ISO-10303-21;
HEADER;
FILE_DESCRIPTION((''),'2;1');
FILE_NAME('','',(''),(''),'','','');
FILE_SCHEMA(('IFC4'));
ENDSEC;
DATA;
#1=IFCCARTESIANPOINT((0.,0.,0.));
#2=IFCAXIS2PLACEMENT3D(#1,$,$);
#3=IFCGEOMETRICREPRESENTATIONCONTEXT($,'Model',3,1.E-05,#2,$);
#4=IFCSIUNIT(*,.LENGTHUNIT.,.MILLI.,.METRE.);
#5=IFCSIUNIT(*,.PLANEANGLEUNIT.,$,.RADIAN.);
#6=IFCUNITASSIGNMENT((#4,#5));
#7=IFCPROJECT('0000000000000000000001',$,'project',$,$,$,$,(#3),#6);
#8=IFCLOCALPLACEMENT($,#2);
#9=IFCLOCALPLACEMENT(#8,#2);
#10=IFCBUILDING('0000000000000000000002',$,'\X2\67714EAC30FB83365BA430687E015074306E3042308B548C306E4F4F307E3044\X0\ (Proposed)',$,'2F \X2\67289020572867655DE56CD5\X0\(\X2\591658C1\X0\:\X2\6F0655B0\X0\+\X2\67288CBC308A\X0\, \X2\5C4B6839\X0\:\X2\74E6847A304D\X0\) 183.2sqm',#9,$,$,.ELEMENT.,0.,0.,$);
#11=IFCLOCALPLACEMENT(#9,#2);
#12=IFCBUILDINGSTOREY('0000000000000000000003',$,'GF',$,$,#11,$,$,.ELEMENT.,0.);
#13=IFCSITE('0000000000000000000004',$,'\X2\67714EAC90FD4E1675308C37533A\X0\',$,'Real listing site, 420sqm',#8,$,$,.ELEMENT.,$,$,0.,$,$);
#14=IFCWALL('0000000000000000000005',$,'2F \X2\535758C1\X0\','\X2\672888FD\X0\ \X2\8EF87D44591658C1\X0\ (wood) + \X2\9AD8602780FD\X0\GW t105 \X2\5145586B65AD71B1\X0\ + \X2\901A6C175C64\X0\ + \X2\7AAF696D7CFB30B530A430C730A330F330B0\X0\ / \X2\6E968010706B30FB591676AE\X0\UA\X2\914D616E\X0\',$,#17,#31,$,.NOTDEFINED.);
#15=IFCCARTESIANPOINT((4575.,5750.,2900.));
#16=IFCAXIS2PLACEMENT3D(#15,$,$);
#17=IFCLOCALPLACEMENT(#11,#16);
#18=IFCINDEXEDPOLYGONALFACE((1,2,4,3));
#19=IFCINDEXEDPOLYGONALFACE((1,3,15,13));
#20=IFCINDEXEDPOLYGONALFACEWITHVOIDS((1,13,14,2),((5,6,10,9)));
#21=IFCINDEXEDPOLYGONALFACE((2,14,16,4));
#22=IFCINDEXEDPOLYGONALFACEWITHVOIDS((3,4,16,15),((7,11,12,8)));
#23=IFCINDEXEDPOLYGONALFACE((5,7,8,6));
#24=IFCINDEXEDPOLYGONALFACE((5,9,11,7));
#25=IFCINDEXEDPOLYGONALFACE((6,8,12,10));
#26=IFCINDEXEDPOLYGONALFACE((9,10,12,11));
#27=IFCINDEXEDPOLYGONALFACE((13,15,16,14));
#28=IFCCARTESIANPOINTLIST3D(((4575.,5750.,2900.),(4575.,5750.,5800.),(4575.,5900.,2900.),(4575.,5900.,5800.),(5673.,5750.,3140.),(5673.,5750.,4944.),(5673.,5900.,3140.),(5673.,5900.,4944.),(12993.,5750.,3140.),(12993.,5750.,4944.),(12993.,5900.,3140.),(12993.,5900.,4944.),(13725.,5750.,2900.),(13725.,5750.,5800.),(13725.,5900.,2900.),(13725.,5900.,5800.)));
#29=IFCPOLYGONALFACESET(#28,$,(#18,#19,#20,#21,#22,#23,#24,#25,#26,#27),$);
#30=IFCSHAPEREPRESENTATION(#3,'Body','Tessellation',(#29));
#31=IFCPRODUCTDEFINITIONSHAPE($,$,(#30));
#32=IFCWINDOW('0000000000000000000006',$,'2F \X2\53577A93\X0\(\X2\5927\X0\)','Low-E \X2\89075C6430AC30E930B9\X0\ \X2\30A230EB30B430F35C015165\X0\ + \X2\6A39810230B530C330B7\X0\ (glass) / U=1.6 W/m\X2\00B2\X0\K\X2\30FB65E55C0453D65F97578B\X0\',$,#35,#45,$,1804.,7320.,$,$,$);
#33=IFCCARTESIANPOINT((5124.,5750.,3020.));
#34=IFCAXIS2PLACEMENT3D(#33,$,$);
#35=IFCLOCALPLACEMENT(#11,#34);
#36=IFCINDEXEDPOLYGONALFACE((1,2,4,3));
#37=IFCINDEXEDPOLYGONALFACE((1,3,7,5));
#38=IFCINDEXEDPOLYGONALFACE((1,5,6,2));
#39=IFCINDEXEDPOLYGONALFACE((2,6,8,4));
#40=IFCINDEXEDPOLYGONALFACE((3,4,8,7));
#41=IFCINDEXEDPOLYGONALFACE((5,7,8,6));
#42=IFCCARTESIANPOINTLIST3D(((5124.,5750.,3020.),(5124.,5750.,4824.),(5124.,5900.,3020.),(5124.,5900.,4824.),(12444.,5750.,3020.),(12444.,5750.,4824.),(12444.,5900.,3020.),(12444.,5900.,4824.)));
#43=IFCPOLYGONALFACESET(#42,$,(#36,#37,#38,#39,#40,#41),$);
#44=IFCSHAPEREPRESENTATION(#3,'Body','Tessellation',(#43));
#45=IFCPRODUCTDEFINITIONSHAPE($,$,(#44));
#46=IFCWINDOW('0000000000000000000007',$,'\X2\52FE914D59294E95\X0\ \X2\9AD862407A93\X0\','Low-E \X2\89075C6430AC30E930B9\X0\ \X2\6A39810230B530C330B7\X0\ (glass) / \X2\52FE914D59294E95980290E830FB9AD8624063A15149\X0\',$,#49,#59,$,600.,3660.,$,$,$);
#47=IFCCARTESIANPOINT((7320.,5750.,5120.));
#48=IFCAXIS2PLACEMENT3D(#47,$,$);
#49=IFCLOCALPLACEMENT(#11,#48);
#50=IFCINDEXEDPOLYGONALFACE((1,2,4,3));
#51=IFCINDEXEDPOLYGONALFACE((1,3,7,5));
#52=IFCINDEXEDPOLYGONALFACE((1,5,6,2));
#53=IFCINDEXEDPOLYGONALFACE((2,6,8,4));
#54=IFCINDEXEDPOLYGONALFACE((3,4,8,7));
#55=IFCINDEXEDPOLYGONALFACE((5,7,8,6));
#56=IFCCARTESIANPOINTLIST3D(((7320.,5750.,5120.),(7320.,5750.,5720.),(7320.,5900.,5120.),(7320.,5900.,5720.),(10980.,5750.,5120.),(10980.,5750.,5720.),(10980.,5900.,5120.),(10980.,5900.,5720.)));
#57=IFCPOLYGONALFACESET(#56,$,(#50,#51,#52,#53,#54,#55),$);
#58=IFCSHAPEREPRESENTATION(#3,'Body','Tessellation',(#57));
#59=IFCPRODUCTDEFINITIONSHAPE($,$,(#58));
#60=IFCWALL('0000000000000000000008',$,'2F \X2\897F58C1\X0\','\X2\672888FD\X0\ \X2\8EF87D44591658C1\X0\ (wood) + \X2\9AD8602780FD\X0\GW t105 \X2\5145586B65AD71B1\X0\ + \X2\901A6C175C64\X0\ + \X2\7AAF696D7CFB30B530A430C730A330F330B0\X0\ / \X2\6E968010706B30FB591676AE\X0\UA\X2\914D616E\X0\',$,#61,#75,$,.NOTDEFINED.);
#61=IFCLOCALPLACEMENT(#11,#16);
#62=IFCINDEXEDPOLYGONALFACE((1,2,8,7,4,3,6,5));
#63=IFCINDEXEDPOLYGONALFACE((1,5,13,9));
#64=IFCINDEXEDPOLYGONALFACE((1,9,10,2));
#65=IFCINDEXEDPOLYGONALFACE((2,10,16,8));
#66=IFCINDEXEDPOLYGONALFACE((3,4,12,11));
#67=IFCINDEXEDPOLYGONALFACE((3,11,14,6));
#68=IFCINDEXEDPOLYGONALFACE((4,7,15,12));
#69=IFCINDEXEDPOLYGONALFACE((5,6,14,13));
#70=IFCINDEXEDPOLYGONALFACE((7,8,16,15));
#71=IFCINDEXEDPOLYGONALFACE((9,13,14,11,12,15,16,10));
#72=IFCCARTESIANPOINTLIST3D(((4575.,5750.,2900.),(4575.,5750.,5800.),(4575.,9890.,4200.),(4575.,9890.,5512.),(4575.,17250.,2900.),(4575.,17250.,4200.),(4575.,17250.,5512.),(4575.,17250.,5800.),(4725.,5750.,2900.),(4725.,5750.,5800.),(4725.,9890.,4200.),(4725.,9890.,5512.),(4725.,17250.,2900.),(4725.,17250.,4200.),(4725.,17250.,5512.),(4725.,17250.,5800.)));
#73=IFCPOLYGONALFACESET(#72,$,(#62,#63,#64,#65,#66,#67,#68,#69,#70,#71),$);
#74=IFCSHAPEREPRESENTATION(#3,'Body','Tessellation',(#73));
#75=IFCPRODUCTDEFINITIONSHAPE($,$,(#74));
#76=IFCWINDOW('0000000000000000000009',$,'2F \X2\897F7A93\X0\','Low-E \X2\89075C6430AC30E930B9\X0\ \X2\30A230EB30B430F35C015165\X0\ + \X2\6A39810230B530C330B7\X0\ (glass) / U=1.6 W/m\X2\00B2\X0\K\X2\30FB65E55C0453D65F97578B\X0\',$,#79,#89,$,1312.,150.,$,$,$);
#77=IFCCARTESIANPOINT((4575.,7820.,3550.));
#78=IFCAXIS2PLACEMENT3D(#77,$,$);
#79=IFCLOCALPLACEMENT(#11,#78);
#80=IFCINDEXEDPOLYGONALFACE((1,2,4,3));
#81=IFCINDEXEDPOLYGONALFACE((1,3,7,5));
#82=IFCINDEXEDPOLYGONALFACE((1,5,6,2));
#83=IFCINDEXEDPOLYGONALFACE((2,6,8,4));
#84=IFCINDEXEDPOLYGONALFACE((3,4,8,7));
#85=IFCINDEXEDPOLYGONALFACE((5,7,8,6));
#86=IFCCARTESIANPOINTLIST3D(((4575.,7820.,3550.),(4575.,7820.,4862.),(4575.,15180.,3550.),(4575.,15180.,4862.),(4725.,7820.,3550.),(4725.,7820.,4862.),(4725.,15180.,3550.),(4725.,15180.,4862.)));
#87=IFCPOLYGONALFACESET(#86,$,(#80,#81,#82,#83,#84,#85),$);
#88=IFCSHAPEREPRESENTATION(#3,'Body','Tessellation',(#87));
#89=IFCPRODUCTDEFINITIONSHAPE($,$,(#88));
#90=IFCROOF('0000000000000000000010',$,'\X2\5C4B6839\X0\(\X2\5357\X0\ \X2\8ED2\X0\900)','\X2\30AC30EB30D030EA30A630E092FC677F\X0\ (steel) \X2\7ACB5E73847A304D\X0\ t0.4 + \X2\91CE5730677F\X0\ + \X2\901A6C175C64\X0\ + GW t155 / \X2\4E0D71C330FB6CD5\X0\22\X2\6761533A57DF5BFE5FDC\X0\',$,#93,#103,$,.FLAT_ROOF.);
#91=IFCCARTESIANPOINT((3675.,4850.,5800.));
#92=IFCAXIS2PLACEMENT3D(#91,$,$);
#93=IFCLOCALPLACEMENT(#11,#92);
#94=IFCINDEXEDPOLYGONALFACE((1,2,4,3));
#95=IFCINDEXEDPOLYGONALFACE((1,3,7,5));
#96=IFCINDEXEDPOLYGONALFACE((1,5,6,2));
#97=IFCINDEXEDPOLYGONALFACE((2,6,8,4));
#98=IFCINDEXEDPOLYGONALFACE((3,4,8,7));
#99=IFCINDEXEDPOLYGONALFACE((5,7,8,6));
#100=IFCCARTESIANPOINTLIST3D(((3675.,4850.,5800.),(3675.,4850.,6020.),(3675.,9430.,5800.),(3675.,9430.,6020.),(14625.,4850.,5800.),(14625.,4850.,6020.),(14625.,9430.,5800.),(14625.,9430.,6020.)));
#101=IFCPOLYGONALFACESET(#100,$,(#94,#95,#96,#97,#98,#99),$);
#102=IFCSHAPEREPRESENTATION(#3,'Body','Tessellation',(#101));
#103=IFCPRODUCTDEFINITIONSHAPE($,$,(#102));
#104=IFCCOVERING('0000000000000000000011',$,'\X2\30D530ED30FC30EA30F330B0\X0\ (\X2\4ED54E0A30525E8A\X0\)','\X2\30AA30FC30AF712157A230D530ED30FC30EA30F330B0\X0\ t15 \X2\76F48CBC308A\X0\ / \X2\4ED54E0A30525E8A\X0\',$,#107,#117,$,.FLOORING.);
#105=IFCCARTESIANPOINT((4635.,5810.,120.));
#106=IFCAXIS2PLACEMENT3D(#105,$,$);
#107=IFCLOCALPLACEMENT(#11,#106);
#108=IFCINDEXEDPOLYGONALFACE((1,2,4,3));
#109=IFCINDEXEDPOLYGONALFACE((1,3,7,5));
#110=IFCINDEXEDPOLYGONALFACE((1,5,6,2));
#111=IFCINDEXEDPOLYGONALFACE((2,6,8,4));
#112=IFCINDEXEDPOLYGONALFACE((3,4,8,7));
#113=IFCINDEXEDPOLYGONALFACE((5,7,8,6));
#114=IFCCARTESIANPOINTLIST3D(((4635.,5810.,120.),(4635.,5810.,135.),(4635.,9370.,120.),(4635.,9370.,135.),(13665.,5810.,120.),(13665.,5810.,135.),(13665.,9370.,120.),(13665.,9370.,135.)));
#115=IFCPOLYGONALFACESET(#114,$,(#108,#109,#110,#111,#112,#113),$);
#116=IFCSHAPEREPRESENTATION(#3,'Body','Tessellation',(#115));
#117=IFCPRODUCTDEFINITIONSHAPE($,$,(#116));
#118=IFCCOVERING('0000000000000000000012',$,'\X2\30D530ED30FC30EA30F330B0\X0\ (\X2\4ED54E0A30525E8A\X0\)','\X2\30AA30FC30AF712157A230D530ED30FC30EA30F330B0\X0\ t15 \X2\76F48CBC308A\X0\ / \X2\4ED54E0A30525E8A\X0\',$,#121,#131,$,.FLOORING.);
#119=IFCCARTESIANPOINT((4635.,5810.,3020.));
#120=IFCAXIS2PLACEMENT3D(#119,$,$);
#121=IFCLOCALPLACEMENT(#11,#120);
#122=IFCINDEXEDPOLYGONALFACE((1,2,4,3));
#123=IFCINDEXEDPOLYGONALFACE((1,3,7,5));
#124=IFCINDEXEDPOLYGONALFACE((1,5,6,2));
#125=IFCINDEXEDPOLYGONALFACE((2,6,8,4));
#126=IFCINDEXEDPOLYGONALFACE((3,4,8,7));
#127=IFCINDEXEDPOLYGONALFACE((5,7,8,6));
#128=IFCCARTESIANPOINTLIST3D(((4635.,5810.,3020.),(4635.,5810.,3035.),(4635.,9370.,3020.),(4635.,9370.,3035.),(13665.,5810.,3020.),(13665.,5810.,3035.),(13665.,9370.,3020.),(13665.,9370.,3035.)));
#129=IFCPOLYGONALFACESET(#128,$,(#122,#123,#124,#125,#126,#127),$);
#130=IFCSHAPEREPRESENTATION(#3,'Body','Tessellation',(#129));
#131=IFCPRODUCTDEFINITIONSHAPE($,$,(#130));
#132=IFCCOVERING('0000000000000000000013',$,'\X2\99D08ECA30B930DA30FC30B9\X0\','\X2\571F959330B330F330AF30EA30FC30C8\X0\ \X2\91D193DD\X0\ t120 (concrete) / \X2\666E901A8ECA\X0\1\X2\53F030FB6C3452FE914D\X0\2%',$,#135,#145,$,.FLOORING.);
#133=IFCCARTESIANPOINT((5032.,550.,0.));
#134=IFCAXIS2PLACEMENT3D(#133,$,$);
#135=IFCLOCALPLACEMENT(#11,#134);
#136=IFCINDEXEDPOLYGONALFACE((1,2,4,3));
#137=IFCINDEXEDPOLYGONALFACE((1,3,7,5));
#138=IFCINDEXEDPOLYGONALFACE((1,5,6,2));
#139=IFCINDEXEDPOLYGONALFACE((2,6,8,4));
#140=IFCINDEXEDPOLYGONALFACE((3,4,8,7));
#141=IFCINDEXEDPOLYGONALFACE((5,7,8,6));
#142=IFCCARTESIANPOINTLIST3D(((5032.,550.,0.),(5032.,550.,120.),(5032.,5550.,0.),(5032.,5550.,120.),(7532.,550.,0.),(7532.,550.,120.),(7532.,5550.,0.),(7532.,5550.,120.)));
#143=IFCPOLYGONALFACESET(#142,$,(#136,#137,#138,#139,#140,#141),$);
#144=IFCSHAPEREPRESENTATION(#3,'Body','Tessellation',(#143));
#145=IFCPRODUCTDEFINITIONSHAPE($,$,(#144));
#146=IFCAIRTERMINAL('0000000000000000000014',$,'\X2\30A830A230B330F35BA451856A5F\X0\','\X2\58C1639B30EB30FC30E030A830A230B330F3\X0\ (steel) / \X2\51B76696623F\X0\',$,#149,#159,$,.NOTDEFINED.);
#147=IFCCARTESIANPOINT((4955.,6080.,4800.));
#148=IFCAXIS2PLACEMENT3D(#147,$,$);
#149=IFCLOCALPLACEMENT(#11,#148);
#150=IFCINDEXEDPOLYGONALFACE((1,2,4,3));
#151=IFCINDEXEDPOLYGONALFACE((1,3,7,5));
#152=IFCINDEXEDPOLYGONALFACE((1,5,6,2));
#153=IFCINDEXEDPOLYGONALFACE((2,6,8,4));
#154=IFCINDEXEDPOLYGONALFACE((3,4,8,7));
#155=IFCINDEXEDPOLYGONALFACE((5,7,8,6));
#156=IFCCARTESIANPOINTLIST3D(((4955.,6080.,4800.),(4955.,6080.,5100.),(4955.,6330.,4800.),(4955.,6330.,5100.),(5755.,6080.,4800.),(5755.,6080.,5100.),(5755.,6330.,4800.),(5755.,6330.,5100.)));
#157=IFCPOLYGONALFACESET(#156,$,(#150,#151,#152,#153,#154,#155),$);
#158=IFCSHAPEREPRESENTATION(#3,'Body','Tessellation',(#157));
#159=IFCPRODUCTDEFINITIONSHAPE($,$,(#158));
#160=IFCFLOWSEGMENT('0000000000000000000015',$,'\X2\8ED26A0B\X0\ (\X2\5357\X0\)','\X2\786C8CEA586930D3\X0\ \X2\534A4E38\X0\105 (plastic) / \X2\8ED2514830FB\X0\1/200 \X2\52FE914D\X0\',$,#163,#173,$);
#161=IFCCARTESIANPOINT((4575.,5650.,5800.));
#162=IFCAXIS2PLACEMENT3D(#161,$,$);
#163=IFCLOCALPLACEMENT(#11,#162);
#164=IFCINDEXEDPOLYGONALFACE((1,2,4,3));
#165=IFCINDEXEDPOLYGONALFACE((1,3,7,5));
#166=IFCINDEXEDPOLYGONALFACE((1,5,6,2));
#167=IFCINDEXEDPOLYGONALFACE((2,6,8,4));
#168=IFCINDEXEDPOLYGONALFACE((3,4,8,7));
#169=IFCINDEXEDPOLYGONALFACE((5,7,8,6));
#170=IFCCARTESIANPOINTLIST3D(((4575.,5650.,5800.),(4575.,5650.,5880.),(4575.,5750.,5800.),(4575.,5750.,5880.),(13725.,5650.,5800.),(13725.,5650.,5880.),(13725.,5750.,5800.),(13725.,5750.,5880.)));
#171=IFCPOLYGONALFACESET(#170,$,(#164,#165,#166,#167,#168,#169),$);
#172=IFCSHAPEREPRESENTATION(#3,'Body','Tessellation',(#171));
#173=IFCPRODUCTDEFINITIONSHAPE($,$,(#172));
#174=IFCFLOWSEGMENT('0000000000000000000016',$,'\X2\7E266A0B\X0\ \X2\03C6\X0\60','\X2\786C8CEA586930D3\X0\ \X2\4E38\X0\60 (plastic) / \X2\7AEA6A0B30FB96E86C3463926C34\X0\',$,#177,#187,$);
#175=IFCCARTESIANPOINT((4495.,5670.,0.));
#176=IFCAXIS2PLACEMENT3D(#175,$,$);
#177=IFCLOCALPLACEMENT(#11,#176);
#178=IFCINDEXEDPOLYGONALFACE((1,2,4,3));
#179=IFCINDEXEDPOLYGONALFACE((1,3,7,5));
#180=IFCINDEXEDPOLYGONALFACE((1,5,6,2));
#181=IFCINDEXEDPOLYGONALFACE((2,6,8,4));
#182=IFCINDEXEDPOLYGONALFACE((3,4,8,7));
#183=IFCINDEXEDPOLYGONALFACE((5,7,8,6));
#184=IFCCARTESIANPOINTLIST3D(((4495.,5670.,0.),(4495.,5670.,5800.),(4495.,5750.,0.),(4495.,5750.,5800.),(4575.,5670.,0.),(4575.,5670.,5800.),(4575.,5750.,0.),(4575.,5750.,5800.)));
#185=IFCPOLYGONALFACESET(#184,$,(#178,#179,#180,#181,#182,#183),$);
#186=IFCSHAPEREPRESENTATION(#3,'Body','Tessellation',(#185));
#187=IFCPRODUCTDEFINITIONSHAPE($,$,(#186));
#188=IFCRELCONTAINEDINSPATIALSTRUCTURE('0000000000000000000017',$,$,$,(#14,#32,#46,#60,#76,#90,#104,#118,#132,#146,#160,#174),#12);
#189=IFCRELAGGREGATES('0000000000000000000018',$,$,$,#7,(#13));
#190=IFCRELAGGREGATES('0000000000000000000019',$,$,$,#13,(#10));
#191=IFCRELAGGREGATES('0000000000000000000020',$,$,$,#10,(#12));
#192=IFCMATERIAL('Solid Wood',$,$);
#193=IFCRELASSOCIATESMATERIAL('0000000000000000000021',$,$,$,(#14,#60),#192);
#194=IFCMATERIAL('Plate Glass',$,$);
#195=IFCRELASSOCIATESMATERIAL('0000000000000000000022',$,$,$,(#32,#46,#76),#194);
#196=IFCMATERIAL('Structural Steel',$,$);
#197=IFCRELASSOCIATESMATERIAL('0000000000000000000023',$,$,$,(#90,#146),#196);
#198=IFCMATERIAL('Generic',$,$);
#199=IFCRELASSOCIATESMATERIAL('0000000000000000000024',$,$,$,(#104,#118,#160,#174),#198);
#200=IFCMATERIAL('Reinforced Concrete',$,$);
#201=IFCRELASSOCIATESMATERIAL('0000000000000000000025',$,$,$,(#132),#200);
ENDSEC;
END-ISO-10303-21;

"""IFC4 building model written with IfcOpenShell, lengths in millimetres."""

from ifc_helpers import new_model, si_unit, frame, frame_2d, origin, place, context, project, spatial, rectangle, extrude, material, element, fill, save


model = new_model("IFC4")

# Units and contexts
model_context = context("Model", 3, precision=1e-05, world=origin())
ifc_project = project(units=[si_unit("LENGTHUNIT", "METRE", prefix="MILLI"), si_unit("PLANEANGLEUNIT", "RADIAN")], contexts=[model_context])

# Site, building, storey
site_placement = place(None, origin())
site = spatial("IfcSite", under=ifc_project, at=site_placement, Name="東京都世田谷区", ObjectType="Real listing site, 420sqm", CompositionType="ELEMENT", RefElevation=0.0)
building_placement = place(site_placement, origin())
building = spatial("IfcBuilding", under=site, at=building_placement, Name="東京・茶室と縁側のある和の住まい (Proposed)", ObjectType="2F 木造在来工法(外壁:漆喰+木貼り, 屋根:瓦葺き) 183.2sqm", CompositionType="ELEMENT", ElevationOfRefHeight=0.0, ElevationOfTerrain=0.0)
storey_placement = place(building_placement, origin())
storey = spatial("IfcBuildingStorey", under=building, at=storey_placement, Name="GF", CompositionType="ELEMENT", Elevation=0.0)

# Shared definitions
ifc_material_1 = material(Name="Solid Wood")

# Shared definitions
ifc_material_2 = material(Name="Reinforced Concrete")

# Shared definitions
ifc_material_3 = material(Name="Plate Glass")

# Wall, openings, windows
wall_1_placement = place(storey_placement, frame((4575.0, 5750.0, 2900.0)))
wall_1 = element("IfcWall", 1, at=wall_1_placement, inside=storey, material=ifc_material_1, Name="2F 南壁", Description="木製 軸組外壁 (wood) + 高性能GW t105 充填断熱 + 通気層 + 窯業系サイディング / 準耐火・外皮UA配慮", PredefinedType="NOTDEFINED", context=model_context, shape_type="SweptSolid", body=[
    extrude(rectangle(XDim=9150.0, YDim=150.0, at=frame_2d((4575.0, 75.0))), frame((4575.0, 5750.0, 2900.0)), (0.0, 0.0, 1.0), 2900.0),
])
opening_1_placement = place(storey_placement, frame((5124.0, 5750.0, 3020.0)))
opening_1 = element("IfcOpeningElement", 2, at=opening_1_placement, cuts=wall_1, PredefinedType="NOTDEFINED", context=model_context, shape_type="SweptSolid", body=[
    extrude(rectangle(XDim=7320.0, YDim=150.0, at=frame_2d((3660.0, 75.0))), frame((5124.0, 5750.0, 3020.0)), (0.0, 0.0, 1.0), 1804.0),
])
opening_2_placement = place(storey_placement, frame((7320.0, 5750.0, 5120.0)))
opening_2 = element("IfcOpeningElement", 3, at=opening_2_placement, cuts=wall_1, PredefinedType="NOTDEFINED", context=model_context, shape_type="SweptSolid", body=[
    extrude(rectangle(XDim=3660.0, YDim=150.0, at=frame_2d((1830.0, 75.0))), frame((7320.0, 5750.0, 5120.0)), (0.0, 0.0, 1.0), 600.0),
])
window_1_placement = place(storey_placement, frame((5124.0, 5750.0, 3020.0)))
window_1 = element("IfcWindow", 4, at=window_1_placement, inside=storey, material=ifc_material_3, Name="2F 南窓(大)", Description="Low-E 複層ガラス アルゴン封入 + 樹脂サッシ (glass) / U=1.6 W/m²K・日射取得型", OverallHeight=1804.0, OverallWidth=7320.0, context=model_context, shape_type="SweptSolid", body=[
    extrude(rectangle(XDim=7320.0, YDim=150.0, at=frame_2d((3660.0, 75.0))), frame((5124.0, 5750.0, 3020.0)), (0.0, 0.0, 1.0), 1804.0),
])
fill(opening_1, window_1)
window_2_placement = place(storey_placement, frame((7320.0, 5750.0, 5120.0)))
window_2 = element("IfcWindow", 5, at=window_2_placement, inside=storey, material=ifc_material_3, Name="勾配天井 高所窓", Description="Low-E 複層ガラス 樹脂サッシ (glass) / 勾配天井頂部・高所採光", OverallHeight=600.0, OverallWidth=3660.0, context=model_context, shape_type="SweptSolid", body=[
    extrude(rectangle(XDim=3660.0, YDim=150.0, at=frame_2d((1830.0, 75.0))), frame((7320.0, 5750.0, 5120.0)), (0.0, 0.0, 1.0), 600.0),
])
fill(opening_2, window_2)

# Wall, opening, window
wall_2_placement = place(storey_placement, frame((4575.0, 5750.0, 2900.0)))
wall_2 = element("IfcWall", 6, at=wall_2_placement, inside=storey, material=ifc_material_1, Name="2F 西壁", Description="木製 軸組外壁 (wood) + 高性能GW t105 充填断熱 + 通気層 + 窯業系サイディング / 準耐火・外皮UA配慮", PredefinedType="NOTDEFINED", context=model_context, shape_type="SweptSolid", body=[
    extrude(rectangle(XDim=150.0, YDim=11500.0, at=frame_2d((75.0, 5750.0))), frame((4575.0, 5750.0, 2900.0)), (0.0, 0.0, 1.0), 2900.0),
])
opening_3_placement = place(storey_placement, frame((4575.0, 7820.0, 3550.0)))
opening_3 = element("IfcOpeningElement", 7, at=opening_3_placement, cuts=wall_2, PredefinedType="NOTDEFINED", context=model_context, shape_type="SweptSolid", body=[
    extrude(rectangle(XDim=150.0, YDim=7360.0, at=frame_2d((75.0, 3680.0))), frame((4575.0, 7820.0, 3550.0)), (0.0, 0.0, 1.0), 1312.0),
])
window_3_placement = place(storey_placement, frame((4575.0, 7820.0, 3550.0)))
window_3 = element("IfcWindow", 8, at=window_3_placement, inside=storey, material=ifc_material_3, Name="2F 西窓", Description="Low-E 複層ガラス アルゴン封入 + 樹脂サッシ (glass) / U=1.6 W/m²K・日射取得型", OverallHeight=1312.0, OverallWidth=150.0, context=model_context, shape_type="SweptSolid", body=[
    extrude(rectangle(XDim=150.0, YDim=7360.0, at=frame_2d((75.0, 3680.0))), frame((4575.0, 7820.0, 3550.0)), (0.0, 0.0, 1.0), 1312.0),
])
fill(opening_3, window_3)

# Roof
ifc_material_4 = material(Name="Structural Steel")
for number, where, name in (
    (9, (3675.0, 4850.0, 5800.0), "屋根(南 軒900)"),
):
    element("IfcRoof", number, at=place(storey_placement, frame(where)), inside=storey, material=ifc_material_4, Name=name, Description="ガルバリウム鋼板 (steel) 立平葺き t0.4 + 野地板 + 通気層 + GW t155 / 不燃・法22条区域対応", PredefinedType="FLAT_ROOF", context=model_context, shape_type="SweptSolid", body=[
        extrude(rectangle(XDim=10950.0, YDim=4580.0, at=frame_2d((5475.0, 2290.0))), frame((3675.0, 4850.0, 5800.0)), (0.0, 0.0, 1.0), 220.0),
    ])

# Coverings
ifc_material_5 = material(Name="Generic")
covering_1_placement = place(storey_placement, frame((4635.0, 5810.0, 120.0)))
element("IfcCovering", 10, at=covering_1_placement, inside=storey, material=ifc_material_5, Name="フローリング (仕上げ床)", Description="オーク無垢フローリング t15 直貼り / 仕上げ床", PredefinedType="FLOORING", context=model_context, shape_type="SweptSolid", body=[
    extrude(rectangle(XDim=9030.0, YDim=3560.0, at=frame_2d((4515.0, 1780.0))), frame((4635.0, 5810.0, 120.0)), (0.0, 0.0, 1.0), 15.0),
])
covering_2_placement = place(storey_placement, frame((4635.0, 5810.0, 3020.0)))
element("IfcCovering", 11, at=covering_2_placement, inside=storey, material=ifc_material_5, Name="フローリング (仕上げ床)", Description="オーク無垢フローリング t15 直貼り / 仕上げ床", PredefinedType="FLOORING", context=model_context, shape_type="SweptSolid", body=[
    extrude(rectangle(XDim=9030.0, YDim=3560.0, at=frame_2d((4515.0, 1780.0))), frame((4635.0, 5810.0, 3020.0)), (0.0, 0.0, 1.0), 15.0),
])
covering_3_placement = place(storey_placement, frame((5032.0, 550.0, 0.0)))
element("IfcCovering", 12, at=covering_3_placement, inside=storey, material=ifc_material_2, Name="駐車スペース", Description="土間コンクリート 金鏝 t120 (concrete) / 普通車1台・水勾配2%", PredefinedType="FLOORING", context=model_context, shape_type="SweptSolid", body=[
    extrude(rectangle(XDim=2500.0, YDim=5000.0, at=frame_2d((1250.0, 2500.0))), frame((5032.0, 550.0, 0.0)), (0.0, 0.0, 1.0), 120.0),
])

# Air terminal
air_terminal_placement = place(storey_placement, frame((4955.0, 6080.0, 4800.0)))
element("IfcAirTerminal", 13, at=air_terminal_placement, inside=storey, material=ifc_material_4, Name="エアコン室内機", Description="壁掛ルームエアコン (steel) / 冷暖房", PredefinedType="NOTDEFINED", context=model_context, shape_type="SweptSolid", body=[
    extrude(rectangle(XDim=800.0, YDim=250.0, at=frame_2d((400.0, 125.0))), frame((4955.0, 6080.0, 4800.0)), (0.0, 0.0, 1.0), 300.0),
])

# Flow segments
flow_segment_1_placement = place(storey_placement, frame((4575.0, 5650.0, 5800.0)))
element("IfcFlowSegment", 14, at=flow_segment_1_placement, inside=storey, material=ifc_material_5, Name="軒樋 (南)", Description="硬質塩ビ 半丸105 (plastic) / 軒先・1/200 勾配", context=model_context, shape_type="SweptSolid", body=[
    extrude(rectangle(XDim=9150.0, YDim=100.0, at=frame_2d((4575.0, 50.0))), frame((4575.0, 5650.0, 5800.0)), (0.0, 0.0, 1.0), 80.0),
])
flow_segment_2_placement = place(storey_placement, frame((4495.0, 5670.0, 0.0)))
element("IfcFlowSegment", 15, at=flow_segment_2_placement, inside=storey, material=ifc_material_5, Name="縦樋 φ60", Description="硬質塩ビ 丸60 (plastic) / 竪樋・雨水排水", context=model_context, shape_type="SweptSolid", body=[
    extrude(rectangle(XDim=80.0, YDim=80.0, at=frame_2d((40.0, 40.0))), frame((4495.0, 5670.0, 0.0)), (0.0, 0.0, 1.0), 5800.0),
])

save(model, "model.ifc")
